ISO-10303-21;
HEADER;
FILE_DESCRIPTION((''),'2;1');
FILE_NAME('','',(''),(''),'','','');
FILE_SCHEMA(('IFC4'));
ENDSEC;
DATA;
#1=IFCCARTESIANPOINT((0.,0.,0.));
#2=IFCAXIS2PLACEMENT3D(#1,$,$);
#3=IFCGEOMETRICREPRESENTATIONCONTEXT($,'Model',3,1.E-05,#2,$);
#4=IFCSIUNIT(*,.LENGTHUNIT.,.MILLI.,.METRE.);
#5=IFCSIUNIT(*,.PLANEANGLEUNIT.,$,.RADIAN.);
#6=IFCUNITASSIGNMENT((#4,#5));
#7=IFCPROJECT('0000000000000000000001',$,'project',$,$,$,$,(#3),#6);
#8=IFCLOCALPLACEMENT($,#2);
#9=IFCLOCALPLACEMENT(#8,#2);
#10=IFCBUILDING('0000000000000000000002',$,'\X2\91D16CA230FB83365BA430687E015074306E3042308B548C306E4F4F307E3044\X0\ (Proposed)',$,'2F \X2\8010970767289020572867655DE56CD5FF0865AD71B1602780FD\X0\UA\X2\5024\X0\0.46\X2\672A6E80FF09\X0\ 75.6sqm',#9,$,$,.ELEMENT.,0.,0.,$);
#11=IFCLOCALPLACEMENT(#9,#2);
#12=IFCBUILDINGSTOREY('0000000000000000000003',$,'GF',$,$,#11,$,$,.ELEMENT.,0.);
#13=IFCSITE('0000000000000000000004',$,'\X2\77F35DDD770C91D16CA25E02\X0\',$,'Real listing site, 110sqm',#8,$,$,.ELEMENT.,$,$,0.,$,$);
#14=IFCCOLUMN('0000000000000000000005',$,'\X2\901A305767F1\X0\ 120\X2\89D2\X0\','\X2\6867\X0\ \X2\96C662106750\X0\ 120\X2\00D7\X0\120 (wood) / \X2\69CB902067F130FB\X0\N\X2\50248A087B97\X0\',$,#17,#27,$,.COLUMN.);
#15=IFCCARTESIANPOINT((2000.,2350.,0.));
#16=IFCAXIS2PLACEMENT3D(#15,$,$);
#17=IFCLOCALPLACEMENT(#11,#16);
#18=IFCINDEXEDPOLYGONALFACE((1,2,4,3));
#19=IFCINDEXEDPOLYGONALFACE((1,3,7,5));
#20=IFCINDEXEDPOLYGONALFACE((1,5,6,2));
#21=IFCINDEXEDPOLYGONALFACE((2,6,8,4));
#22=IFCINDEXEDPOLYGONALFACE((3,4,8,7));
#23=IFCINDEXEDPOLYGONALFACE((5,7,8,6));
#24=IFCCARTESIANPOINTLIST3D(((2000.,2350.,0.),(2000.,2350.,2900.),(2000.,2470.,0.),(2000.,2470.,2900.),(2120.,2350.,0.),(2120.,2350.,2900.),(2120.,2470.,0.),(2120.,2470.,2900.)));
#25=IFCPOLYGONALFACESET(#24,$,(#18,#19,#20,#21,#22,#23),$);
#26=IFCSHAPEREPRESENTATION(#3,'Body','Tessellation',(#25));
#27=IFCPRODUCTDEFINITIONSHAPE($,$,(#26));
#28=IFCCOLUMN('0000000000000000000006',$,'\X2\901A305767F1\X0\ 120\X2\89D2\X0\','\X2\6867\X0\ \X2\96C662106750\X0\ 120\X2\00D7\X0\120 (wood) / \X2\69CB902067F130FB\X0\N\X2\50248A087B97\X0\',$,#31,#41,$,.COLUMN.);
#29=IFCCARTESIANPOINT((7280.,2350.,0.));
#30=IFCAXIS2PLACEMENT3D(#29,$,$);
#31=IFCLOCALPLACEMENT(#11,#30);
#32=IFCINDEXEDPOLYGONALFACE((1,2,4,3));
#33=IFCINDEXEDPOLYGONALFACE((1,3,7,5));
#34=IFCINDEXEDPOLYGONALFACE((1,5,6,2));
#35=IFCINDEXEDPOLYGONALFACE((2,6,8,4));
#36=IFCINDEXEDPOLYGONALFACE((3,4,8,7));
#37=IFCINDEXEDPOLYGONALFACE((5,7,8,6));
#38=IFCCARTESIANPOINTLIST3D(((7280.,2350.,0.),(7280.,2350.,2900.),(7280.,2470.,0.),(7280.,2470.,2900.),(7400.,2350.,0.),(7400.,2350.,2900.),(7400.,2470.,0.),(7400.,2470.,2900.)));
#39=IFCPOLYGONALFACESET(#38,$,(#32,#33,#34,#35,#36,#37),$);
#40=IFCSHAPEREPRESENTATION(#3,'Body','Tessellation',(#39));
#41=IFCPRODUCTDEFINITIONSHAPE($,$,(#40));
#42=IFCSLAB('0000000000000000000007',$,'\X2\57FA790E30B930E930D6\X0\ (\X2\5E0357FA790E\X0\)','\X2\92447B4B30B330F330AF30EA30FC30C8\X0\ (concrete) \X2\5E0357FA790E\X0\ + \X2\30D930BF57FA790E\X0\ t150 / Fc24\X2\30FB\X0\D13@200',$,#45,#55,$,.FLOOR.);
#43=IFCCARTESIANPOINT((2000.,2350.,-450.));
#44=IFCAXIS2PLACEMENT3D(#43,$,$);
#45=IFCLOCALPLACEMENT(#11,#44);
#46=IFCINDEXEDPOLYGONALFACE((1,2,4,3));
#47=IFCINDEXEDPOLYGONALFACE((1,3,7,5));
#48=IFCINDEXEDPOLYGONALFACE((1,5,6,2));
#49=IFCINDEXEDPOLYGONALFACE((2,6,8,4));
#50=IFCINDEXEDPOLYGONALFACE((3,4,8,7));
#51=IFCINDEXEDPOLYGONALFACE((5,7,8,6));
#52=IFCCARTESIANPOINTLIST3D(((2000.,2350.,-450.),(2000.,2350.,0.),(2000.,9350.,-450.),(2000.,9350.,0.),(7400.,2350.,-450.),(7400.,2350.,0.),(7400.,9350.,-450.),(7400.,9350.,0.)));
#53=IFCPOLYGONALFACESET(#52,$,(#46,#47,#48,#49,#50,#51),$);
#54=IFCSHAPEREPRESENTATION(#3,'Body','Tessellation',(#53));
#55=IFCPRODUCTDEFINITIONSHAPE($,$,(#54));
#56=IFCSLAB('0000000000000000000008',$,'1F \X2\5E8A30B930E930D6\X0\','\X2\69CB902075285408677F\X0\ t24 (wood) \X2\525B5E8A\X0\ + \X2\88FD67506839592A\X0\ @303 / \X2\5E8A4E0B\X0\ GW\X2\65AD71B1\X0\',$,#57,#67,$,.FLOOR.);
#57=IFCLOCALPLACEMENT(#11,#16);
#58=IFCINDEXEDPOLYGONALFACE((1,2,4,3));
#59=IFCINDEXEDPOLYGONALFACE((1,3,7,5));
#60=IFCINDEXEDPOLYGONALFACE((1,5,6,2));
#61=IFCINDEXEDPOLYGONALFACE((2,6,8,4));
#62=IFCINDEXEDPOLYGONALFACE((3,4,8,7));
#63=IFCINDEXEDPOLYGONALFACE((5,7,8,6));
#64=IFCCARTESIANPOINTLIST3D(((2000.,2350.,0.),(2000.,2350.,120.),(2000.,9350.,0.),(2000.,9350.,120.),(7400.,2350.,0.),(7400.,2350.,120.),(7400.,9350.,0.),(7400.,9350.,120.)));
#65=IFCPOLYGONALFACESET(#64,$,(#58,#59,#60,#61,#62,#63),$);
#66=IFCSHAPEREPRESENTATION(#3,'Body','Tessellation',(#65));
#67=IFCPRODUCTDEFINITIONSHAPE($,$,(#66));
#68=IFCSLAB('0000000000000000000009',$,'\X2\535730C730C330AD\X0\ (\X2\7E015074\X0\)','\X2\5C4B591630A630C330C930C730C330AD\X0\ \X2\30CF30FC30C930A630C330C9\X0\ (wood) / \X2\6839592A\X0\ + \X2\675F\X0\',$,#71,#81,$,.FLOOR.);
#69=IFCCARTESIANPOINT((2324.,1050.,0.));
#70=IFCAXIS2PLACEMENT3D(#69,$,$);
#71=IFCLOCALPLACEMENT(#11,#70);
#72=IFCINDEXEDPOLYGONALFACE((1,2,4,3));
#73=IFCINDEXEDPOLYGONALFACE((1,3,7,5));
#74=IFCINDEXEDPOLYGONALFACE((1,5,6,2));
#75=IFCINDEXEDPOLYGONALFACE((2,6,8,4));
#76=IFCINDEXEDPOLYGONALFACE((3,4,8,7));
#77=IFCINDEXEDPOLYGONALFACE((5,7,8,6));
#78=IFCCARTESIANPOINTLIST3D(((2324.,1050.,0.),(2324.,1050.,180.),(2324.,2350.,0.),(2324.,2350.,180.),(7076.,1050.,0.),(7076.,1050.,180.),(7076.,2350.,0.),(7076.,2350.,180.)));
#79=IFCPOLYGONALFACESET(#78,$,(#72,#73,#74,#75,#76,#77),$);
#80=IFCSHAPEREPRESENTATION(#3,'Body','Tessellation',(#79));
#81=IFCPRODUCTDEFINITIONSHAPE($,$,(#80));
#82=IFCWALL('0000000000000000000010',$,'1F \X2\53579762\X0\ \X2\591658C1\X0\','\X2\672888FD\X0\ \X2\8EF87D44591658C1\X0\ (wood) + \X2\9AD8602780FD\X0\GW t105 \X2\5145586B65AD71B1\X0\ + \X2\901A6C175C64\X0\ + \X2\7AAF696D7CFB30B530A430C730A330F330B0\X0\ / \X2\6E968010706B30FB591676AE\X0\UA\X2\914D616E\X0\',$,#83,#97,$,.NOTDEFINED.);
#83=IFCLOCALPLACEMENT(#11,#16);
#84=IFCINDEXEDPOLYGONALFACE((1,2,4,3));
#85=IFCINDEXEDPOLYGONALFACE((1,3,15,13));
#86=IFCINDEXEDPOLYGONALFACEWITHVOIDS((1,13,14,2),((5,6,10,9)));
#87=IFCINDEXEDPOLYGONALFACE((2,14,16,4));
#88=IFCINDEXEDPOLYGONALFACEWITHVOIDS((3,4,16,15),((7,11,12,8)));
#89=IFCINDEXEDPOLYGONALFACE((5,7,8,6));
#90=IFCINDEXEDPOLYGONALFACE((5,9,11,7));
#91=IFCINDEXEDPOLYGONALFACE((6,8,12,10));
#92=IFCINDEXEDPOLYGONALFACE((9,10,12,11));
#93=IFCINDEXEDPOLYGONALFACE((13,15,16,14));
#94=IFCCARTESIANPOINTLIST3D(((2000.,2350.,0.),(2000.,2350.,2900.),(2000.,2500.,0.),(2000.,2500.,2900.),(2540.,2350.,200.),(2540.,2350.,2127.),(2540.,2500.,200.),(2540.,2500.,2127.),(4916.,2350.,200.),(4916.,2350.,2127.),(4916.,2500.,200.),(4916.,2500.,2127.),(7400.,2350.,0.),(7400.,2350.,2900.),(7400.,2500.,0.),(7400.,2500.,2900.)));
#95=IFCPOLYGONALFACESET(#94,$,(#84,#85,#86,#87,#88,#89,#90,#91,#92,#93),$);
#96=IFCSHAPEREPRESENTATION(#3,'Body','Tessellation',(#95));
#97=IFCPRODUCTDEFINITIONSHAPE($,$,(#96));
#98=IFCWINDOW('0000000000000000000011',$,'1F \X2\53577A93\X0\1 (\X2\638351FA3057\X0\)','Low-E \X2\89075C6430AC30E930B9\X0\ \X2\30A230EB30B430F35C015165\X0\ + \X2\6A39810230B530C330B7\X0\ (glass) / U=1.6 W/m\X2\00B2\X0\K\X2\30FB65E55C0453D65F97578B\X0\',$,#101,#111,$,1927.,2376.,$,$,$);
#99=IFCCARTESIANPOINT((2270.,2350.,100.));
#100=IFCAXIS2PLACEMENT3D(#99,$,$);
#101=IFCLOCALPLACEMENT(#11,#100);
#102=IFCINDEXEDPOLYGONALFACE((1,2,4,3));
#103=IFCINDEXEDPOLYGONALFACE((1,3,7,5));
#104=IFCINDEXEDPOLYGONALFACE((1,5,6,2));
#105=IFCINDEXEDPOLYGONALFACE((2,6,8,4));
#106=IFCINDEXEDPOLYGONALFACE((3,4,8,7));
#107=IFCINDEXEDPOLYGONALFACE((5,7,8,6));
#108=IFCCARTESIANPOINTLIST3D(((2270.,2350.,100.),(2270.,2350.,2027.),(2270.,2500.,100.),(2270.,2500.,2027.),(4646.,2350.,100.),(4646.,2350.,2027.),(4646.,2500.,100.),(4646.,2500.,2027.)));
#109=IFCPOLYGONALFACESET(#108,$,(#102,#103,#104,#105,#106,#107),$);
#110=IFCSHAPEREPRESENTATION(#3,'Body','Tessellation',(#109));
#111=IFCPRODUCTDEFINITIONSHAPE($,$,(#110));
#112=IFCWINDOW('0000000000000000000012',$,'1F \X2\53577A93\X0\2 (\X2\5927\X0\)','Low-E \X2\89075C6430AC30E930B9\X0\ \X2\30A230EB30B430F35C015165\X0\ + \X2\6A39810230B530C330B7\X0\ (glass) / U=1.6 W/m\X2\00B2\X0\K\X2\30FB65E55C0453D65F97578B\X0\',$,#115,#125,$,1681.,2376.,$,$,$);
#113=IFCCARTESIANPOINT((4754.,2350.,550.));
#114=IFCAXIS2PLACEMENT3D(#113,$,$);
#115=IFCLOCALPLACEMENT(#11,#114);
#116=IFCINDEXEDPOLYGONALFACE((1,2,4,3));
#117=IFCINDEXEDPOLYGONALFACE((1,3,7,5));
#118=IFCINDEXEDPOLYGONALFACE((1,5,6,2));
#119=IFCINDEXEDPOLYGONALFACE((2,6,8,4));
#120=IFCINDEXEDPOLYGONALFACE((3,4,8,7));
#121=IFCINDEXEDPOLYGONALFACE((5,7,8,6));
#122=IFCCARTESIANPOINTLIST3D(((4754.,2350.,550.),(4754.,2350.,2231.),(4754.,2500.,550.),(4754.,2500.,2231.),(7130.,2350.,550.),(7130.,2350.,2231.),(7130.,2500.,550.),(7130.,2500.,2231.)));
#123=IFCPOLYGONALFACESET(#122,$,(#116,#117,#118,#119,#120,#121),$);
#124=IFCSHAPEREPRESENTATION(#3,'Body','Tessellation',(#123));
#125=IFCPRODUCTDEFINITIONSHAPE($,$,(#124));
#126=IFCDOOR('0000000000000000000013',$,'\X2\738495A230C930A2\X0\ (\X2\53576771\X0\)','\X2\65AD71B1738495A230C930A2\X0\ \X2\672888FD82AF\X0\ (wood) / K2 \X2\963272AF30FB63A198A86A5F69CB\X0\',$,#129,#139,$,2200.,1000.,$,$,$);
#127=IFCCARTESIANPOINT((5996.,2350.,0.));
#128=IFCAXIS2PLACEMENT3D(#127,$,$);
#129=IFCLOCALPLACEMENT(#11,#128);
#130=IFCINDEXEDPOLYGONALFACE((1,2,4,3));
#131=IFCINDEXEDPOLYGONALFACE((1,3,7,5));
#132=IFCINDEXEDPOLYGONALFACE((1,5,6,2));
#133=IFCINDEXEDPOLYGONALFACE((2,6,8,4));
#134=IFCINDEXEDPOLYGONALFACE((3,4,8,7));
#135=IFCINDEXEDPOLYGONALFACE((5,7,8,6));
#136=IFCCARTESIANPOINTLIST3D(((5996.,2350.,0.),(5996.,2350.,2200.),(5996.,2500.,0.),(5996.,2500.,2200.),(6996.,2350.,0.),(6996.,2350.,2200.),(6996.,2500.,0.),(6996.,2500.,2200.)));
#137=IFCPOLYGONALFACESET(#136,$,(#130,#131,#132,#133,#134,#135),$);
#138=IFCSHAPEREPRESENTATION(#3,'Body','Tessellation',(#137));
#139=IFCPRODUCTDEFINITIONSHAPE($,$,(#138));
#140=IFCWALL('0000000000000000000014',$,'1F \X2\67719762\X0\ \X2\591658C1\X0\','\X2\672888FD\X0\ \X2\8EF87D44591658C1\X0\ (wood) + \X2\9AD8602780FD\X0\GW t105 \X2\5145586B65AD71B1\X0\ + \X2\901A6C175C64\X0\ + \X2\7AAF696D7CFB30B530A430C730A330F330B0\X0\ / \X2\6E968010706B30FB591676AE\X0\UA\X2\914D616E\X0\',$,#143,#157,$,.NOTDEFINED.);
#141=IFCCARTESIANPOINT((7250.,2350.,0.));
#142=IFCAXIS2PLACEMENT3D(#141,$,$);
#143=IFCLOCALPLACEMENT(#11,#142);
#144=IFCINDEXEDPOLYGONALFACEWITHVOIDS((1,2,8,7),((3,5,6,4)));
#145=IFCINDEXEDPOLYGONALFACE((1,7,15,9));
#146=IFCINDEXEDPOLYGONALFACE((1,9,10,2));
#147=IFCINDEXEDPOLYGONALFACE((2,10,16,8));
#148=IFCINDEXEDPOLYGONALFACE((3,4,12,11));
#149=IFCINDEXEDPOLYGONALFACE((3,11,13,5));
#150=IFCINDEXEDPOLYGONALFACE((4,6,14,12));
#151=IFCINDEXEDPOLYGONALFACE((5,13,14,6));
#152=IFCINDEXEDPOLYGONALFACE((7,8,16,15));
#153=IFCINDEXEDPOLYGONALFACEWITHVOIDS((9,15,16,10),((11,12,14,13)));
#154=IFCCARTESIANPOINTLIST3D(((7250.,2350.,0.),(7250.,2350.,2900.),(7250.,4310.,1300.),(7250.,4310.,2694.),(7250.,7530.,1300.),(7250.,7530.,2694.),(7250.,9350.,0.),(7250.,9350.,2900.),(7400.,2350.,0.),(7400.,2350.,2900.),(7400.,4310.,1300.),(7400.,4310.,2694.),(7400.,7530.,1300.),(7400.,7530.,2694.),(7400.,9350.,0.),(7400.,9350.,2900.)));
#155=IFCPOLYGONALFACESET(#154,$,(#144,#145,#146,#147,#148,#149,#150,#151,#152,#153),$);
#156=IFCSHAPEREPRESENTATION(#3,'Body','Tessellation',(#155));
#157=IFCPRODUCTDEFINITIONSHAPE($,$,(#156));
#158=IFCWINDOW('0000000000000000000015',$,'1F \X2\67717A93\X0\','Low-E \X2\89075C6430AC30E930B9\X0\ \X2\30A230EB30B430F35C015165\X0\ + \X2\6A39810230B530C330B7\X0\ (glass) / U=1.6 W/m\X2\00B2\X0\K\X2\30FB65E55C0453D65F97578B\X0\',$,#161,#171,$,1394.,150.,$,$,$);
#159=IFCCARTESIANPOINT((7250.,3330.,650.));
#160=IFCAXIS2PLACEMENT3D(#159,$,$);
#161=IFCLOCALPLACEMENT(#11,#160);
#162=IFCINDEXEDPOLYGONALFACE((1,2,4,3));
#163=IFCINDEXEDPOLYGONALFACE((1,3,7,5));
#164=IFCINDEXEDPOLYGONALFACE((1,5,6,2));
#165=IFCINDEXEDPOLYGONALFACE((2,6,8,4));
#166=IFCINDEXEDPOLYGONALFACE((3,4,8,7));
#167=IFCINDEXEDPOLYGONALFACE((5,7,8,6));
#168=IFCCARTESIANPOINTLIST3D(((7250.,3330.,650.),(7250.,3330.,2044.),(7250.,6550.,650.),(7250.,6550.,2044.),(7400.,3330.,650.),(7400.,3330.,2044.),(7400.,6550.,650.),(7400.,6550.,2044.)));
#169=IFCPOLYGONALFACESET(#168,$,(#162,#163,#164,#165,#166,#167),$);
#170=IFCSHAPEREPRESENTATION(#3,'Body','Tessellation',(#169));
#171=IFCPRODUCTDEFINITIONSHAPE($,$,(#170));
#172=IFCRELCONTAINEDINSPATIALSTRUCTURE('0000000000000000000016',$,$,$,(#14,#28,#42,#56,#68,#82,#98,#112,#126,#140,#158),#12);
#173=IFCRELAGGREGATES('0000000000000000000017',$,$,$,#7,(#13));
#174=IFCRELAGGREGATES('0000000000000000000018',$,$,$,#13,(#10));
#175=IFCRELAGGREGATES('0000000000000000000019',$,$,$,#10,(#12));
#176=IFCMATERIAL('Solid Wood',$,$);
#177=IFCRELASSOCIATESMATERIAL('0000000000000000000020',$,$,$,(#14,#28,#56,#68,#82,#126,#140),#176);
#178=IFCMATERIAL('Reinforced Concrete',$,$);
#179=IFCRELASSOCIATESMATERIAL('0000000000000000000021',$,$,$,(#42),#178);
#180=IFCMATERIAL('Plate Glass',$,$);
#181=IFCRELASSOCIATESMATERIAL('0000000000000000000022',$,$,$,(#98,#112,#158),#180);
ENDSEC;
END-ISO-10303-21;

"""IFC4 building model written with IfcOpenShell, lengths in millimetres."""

from ifc_helpers import new_model, si_unit, frame, frame_2d, origin, place, context, project, spatial, rectangle, extrude, material, element, fill, save


model = new_model("IFC4")

# Units and contexts
model_context = context("Model", 3, precision=1e-05, world=origin())
ifc_project = project(units=[si_unit("LENGTHUNIT", "METRE", prefix="MILLI"), si_unit("PLANEANGLEUNIT", "RADIAN")], contexts=[model_context])

# Site, building, storey
site_placement = place(None, origin())
site = spatial("IfcSite", under=ifc_project, at=site_placement, Name="石川県金沢市", ObjectType="Real listing site, 110sqm", CompositionType="ELEMENT", RefElevation=0.0)
building_placement = place(site_placement, origin())
building = spatial("IfcBuilding", under=site, at=building_placement, Name="金沢・茶室と縁側のある和の住まい (Proposed)", ObjectType="2F 耐震木造在来工法（断熱性能UA値0.46未満） 75.6sqm", CompositionType="ELEMENT", ElevationOfRefHeight=0.0, ElevationOfTerrain=0.0)
storey_placement = place(building_placement, origin())
storey = spatial("IfcBuildingStorey", under=building, at=storey_placement, Name="GF", CompositionType="ELEMENT", Elevation=0.0)

# Columns
ifc_material_1 = material(Name="Solid Wood")
column_1_placement = place(storey_placement, frame((2000.0, 2350.0, 0.0)))
element("IfcColumn", 1, at=column_1_placement, inside=storey, material=ifc_material_1, Name="通し柱 120角", Description="桧 集成材 120×120 (wood) / 構造柱・N値計算", PredefinedType="COLUMN", context=model_context, shape_type="SweptSolid", body=[
    extrude(rectangle(XDim=120.0, YDim=120.0, at=frame_2d((60.0, 60.0))), frame((2000.0, 2350.0, 0.0)), (0.0, 0.0, 1.0), 2900.0),
])
column_2_placement = place(storey_placement, frame((7280.0, 2350.0, 0.0)))
element("IfcColumn", 2, at=column_2_placement, inside=storey, material=ifc_material_1, Name="通し柱 120角", Description="桧 集成材 120×120 (wood) / 構造柱・N値計算", PredefinedType="COLUMN", context=model_context, shape_type="SweptSolid", body=[
    extrude(rectangle(XDim=120.0, YDim=120.0, at=frame_2d((60.0, 60.0))), frame((7280.0, 2350.0, 0.0)), (0.0, 0.0, 1.0), 2900.0),
])

# Slabs
ifc_material_2 = material(Name="Reinforced Concrete")
slab_1_placement = place(storey_placement, frame((2000.0, 2350.0, -450.0)))
element("IfcSlab", 3, at=slab_1_placement, inside=storey, material=ifc_material_2, Name="基礎スラブ (布基礎)", Description="鉄筋コンクリート (concrete) 布基礎 + ベタ基礎 t150 / Fc24・D13@200", PredefinedType="FLOOR", context=model_context, shape_type="SweptSolid", body=[
    extrude(rectangle(XDim=5400.0, YDim=7000.0, at=frame_2d((2700.0, 3500.0))), frame((2000.0, 2350.0, -450.0)), (0.0, 0.0, 1.0), 450.0),
])
slab_2_placement = place(storey_placement, frame((2000.0, 2350.0, 0.0)))
element("IfcSlab", 4, at=slab_2_placement, inside=storey, material=ifc_material_1, Name="1F 床スラブ", Description="構造用合板 t24 (wood) 剛床 + 製材根太 @303 / 床下 GW断熱", PredefinedType="FLOOR", context=model_context, shape_type="SweptSolid", body=[
    extrude(rectangle(XDim=5400.0, YDim=7000.0, at=frame_2d((2700.0, 3500.0))), frame((2000.0, 2350.0, 0.0)), (0.0, 0.0, 1.0), 120.0),
])
slab_3_placement = place(storey_placement, frame((2324.0, 1050.0, 0.0)))
element("IfcSlab", 5, at=slab_3_placement, inside=storey, material=ifc_material_1, Name="南デッキ (縁側)", Description="屋外ウッドデッキ ハードウッド (wood) / 根太 + 束", PredefinedType="FLOOR", context=model_context, shape_type="SweptSolid", body=[
    extrude(rectangle(XDim=4752.0, YDim=1300.0, at=frame_2d((2376.0, 650.0))), frame((2324.0, 1050.0, 0.0)), (0.0, 0.0, 1.0), 180.0),
])

# Wall, openings, windows, door
wall_1_placement = place(storey_placement, frame((2000.0, 2350.0, 0.0)))
wall_1 = element("IfcWall", 6, at=wall_1_placement, inside=storey, material=ifc_material_1, Name="1F 南面 外壁", Description="木製 軸組外壁 (wood) + 高性能GW t105 充填断熱 + 通気層 + 窯業系サイディング / 準耐火・外皮UA配慮", PredefinedType="NOTDEFINED", context=model_context, shape_type="SweptSolid", body=[
    extrude(rectangle(XDim=5400.0, YDim=150.0, at=frame_2d((2700.0, 75.0))), frame((2000.0, 2350.0, 0.0)), (0.0, 0.0, 1.0), 2900.0),
])
opening_1_placement = place(storey_placement, frame((2270.0, 2350.0, 100.0)))
opening_1 = element("IfcOpeningElement", 7, at=opening_1_placement, cuts=wall_1, PredefinedType="NOTDEFINED", context=model_context, shape_type="SweptSolid", body=[
    extrude(rectangle(XDim=2376.0, YDim=150.0, at=frame_2d((1188.0, 75.0))), frame((2270.0, 2350.0, 100.0)), (0.0, 0.0, 1.0), 1927.0),
])
opening_2_placement = place(storey_placement, frame((4754.0, 2350.0, 550.0)))
opening_2 = element("IfcOpeningElement", 8, at=opening_2_placement, cuts=wall_1, PredefinedType="NOTDEFINED", context=model_context, shape_type="SweptSolid", body=[
    extrude(rectangle(XDim=2376.0, YDim=150.0, at=frame_2d((1188.0, 75.0))), frame((4754.0, 2350.0, 550.0)), (0.0, 0.0, 1.0), 1681.0),
])
opening_3_placement = place(storey_placement, frame((5996.0, 2350.0, 0.0)))
opening_3 = element("IfcOpeningElement", 9, at=opening_3_placement, cuts=wall_1, PredefinedType="NOTDEFINED", context=model_context, shape_type="SweptSolid", body=[
    extrude(rectangle(XDim=1000.0, YDim=150.0, at=frame_2d((500.0, 75.0))), frame((5996.0, 2350.0, 0.0)), (0.0, 0.0, 1.0), 2200.0),
])
ifc_material_3 = material(Name="Plate Glass")
window_1_placement = place(storey_placement, frame((2270.0, 2350.0, 100.0)))
window_1 = element("IfcWindow", 10, at=window_1_placement, inside=storey, material=ifc_material_3, Name="1F 南窓1 (掃出し)", Description="Low-E 複層ガラス アルゴン封入 + 樹脂サッシ (glass) / U=1.6 W/m²K・日射取得型", OverallHeight=1927.0, OverallWidth=2376.0, context=model_context, shape_type="SweptSolid", body=[
    extrude(rectangle(XDim=2376.0, YDim=150.0, at=frame_2d((1188.0, 75.0))), frame((2270.0, 2350.0, 100.0)), (0.0, 0.0, 1.0), 1927.0),
])
fill(opening_1, window_1)
window_2_placement = place(storey_placement, frame((4754.0, 2350.0, 550.0)))
window_2 = element("IfcWindow", 11, at=window_2_placement, inside=storey, material=ifc_material_3, Name="1F 南窓2 (大)", Description="Low-E 複層ガラス アルゴン封入 + 樹脂サッシ (glass) / U=1.6 W/m²K・日射取得型", OverallHeight=1681.0, OverallWidth=2376.0, context=model_context, shape_type="SweptSolid", body=[
    extrude(rectangle(XDim=2376.0, YDim=150.0, at=frame_2d((1188.0, 75.0))), frame((4754.0, 2350.0, 550.0)), (0.0, 0.0, 1.0), 1681.0),
])
fill(opening_2, window_2)
door_placement = place(storey_placement, frame((5996.0, 2350.0, 0.0)))
door = element("IfcDoor", 12, at=door_placement, inside=storey, material=ifc_material_1, Name="玄関ドア (南東)", Description="断熱玄関ドア 木製芯 (wood) / K2 防犯・採風機構", OverallHeight=2200.0, OverallWidth=1000.0, context=model_context, shape_type="SweptSolid", body=[
    extrude(rectangle(XDim=1000.0, YDim=150.0, at=frame_2d((500.0, 75.0))), frame((5996.0, 2350.0, 0.0)), (0.0, 0.0, 1.0), 2200.0),
])
fill(opening_3, door)

# Wall, opening, window
wall_2_placement = place(storey_placement, frame((7250.0, 2350.0, 0.0)))
wall_2 = element("IfcWall", 13, at=wall_2_placement, inside=storey, material=ifc_material_1, Name="1F 東面 外壁", Description="木製 軸組外壁 (wood) + 高性能GW t105 充填断熱 + 通気層 + 窯業系サイディング / 準耐火・外皮UA配慮", PredefinedType="NOTDEFINED", context=model_context, shape_type="SweptSolid", body=[
    extrude(rectangle(XDim=150.0, YDim=7000.0, at=frame_2d((75.0, 3500.0))), frame((7250.0, 2350.0, 0.0)), (0.0, 0.0, 1.0), 2900.0),
])
opening_4_placement = place(storey_placement, frame((7250.0, 3330.0, 650.0)))
opening_4 = element("IfcOpeningElement", 14, at=opening_4_placement, cuts=wall_2, PredefinedType="NOTDEFINED", context=model_context, shape_type="SweptSolid", body=[
    extrude(rectangle(XDim=150.0, YDim=3220.0, at=frame_2d((75.0, 1610.0))), frame((7250.0, 3330.0, 650.0)), (0.0, 0.0, 1.0), 1394.0),
])
window_3_placement = place(storey_placement, frame((7250.0, 3330.0, 650.0)))
window_3 = element("IfcWindow", 15, at=window_3_placement, inside=storey, material=ifc_material_3, Name="1F 東窓", Description="Low-E 複層ガラス アルゴン封入 + 樹脂サッシ (glass) / U=1.6 W/m²K・日射取得型", OverallHeight=1394.0, OverallWidth=150.0, context=model_context, shape_type="SweptSolid", body=[
    extrude(rectangle(XDim=150.0, YDim=3220.0, at=frame_2d((75.0, 1610.0))), frame((7250.0, 3330.0, 650.0)), (0.0, 0.0, 1.0), 1394.0),
])
fill(opening_4, window_3)

save(model, "model.ifc")
